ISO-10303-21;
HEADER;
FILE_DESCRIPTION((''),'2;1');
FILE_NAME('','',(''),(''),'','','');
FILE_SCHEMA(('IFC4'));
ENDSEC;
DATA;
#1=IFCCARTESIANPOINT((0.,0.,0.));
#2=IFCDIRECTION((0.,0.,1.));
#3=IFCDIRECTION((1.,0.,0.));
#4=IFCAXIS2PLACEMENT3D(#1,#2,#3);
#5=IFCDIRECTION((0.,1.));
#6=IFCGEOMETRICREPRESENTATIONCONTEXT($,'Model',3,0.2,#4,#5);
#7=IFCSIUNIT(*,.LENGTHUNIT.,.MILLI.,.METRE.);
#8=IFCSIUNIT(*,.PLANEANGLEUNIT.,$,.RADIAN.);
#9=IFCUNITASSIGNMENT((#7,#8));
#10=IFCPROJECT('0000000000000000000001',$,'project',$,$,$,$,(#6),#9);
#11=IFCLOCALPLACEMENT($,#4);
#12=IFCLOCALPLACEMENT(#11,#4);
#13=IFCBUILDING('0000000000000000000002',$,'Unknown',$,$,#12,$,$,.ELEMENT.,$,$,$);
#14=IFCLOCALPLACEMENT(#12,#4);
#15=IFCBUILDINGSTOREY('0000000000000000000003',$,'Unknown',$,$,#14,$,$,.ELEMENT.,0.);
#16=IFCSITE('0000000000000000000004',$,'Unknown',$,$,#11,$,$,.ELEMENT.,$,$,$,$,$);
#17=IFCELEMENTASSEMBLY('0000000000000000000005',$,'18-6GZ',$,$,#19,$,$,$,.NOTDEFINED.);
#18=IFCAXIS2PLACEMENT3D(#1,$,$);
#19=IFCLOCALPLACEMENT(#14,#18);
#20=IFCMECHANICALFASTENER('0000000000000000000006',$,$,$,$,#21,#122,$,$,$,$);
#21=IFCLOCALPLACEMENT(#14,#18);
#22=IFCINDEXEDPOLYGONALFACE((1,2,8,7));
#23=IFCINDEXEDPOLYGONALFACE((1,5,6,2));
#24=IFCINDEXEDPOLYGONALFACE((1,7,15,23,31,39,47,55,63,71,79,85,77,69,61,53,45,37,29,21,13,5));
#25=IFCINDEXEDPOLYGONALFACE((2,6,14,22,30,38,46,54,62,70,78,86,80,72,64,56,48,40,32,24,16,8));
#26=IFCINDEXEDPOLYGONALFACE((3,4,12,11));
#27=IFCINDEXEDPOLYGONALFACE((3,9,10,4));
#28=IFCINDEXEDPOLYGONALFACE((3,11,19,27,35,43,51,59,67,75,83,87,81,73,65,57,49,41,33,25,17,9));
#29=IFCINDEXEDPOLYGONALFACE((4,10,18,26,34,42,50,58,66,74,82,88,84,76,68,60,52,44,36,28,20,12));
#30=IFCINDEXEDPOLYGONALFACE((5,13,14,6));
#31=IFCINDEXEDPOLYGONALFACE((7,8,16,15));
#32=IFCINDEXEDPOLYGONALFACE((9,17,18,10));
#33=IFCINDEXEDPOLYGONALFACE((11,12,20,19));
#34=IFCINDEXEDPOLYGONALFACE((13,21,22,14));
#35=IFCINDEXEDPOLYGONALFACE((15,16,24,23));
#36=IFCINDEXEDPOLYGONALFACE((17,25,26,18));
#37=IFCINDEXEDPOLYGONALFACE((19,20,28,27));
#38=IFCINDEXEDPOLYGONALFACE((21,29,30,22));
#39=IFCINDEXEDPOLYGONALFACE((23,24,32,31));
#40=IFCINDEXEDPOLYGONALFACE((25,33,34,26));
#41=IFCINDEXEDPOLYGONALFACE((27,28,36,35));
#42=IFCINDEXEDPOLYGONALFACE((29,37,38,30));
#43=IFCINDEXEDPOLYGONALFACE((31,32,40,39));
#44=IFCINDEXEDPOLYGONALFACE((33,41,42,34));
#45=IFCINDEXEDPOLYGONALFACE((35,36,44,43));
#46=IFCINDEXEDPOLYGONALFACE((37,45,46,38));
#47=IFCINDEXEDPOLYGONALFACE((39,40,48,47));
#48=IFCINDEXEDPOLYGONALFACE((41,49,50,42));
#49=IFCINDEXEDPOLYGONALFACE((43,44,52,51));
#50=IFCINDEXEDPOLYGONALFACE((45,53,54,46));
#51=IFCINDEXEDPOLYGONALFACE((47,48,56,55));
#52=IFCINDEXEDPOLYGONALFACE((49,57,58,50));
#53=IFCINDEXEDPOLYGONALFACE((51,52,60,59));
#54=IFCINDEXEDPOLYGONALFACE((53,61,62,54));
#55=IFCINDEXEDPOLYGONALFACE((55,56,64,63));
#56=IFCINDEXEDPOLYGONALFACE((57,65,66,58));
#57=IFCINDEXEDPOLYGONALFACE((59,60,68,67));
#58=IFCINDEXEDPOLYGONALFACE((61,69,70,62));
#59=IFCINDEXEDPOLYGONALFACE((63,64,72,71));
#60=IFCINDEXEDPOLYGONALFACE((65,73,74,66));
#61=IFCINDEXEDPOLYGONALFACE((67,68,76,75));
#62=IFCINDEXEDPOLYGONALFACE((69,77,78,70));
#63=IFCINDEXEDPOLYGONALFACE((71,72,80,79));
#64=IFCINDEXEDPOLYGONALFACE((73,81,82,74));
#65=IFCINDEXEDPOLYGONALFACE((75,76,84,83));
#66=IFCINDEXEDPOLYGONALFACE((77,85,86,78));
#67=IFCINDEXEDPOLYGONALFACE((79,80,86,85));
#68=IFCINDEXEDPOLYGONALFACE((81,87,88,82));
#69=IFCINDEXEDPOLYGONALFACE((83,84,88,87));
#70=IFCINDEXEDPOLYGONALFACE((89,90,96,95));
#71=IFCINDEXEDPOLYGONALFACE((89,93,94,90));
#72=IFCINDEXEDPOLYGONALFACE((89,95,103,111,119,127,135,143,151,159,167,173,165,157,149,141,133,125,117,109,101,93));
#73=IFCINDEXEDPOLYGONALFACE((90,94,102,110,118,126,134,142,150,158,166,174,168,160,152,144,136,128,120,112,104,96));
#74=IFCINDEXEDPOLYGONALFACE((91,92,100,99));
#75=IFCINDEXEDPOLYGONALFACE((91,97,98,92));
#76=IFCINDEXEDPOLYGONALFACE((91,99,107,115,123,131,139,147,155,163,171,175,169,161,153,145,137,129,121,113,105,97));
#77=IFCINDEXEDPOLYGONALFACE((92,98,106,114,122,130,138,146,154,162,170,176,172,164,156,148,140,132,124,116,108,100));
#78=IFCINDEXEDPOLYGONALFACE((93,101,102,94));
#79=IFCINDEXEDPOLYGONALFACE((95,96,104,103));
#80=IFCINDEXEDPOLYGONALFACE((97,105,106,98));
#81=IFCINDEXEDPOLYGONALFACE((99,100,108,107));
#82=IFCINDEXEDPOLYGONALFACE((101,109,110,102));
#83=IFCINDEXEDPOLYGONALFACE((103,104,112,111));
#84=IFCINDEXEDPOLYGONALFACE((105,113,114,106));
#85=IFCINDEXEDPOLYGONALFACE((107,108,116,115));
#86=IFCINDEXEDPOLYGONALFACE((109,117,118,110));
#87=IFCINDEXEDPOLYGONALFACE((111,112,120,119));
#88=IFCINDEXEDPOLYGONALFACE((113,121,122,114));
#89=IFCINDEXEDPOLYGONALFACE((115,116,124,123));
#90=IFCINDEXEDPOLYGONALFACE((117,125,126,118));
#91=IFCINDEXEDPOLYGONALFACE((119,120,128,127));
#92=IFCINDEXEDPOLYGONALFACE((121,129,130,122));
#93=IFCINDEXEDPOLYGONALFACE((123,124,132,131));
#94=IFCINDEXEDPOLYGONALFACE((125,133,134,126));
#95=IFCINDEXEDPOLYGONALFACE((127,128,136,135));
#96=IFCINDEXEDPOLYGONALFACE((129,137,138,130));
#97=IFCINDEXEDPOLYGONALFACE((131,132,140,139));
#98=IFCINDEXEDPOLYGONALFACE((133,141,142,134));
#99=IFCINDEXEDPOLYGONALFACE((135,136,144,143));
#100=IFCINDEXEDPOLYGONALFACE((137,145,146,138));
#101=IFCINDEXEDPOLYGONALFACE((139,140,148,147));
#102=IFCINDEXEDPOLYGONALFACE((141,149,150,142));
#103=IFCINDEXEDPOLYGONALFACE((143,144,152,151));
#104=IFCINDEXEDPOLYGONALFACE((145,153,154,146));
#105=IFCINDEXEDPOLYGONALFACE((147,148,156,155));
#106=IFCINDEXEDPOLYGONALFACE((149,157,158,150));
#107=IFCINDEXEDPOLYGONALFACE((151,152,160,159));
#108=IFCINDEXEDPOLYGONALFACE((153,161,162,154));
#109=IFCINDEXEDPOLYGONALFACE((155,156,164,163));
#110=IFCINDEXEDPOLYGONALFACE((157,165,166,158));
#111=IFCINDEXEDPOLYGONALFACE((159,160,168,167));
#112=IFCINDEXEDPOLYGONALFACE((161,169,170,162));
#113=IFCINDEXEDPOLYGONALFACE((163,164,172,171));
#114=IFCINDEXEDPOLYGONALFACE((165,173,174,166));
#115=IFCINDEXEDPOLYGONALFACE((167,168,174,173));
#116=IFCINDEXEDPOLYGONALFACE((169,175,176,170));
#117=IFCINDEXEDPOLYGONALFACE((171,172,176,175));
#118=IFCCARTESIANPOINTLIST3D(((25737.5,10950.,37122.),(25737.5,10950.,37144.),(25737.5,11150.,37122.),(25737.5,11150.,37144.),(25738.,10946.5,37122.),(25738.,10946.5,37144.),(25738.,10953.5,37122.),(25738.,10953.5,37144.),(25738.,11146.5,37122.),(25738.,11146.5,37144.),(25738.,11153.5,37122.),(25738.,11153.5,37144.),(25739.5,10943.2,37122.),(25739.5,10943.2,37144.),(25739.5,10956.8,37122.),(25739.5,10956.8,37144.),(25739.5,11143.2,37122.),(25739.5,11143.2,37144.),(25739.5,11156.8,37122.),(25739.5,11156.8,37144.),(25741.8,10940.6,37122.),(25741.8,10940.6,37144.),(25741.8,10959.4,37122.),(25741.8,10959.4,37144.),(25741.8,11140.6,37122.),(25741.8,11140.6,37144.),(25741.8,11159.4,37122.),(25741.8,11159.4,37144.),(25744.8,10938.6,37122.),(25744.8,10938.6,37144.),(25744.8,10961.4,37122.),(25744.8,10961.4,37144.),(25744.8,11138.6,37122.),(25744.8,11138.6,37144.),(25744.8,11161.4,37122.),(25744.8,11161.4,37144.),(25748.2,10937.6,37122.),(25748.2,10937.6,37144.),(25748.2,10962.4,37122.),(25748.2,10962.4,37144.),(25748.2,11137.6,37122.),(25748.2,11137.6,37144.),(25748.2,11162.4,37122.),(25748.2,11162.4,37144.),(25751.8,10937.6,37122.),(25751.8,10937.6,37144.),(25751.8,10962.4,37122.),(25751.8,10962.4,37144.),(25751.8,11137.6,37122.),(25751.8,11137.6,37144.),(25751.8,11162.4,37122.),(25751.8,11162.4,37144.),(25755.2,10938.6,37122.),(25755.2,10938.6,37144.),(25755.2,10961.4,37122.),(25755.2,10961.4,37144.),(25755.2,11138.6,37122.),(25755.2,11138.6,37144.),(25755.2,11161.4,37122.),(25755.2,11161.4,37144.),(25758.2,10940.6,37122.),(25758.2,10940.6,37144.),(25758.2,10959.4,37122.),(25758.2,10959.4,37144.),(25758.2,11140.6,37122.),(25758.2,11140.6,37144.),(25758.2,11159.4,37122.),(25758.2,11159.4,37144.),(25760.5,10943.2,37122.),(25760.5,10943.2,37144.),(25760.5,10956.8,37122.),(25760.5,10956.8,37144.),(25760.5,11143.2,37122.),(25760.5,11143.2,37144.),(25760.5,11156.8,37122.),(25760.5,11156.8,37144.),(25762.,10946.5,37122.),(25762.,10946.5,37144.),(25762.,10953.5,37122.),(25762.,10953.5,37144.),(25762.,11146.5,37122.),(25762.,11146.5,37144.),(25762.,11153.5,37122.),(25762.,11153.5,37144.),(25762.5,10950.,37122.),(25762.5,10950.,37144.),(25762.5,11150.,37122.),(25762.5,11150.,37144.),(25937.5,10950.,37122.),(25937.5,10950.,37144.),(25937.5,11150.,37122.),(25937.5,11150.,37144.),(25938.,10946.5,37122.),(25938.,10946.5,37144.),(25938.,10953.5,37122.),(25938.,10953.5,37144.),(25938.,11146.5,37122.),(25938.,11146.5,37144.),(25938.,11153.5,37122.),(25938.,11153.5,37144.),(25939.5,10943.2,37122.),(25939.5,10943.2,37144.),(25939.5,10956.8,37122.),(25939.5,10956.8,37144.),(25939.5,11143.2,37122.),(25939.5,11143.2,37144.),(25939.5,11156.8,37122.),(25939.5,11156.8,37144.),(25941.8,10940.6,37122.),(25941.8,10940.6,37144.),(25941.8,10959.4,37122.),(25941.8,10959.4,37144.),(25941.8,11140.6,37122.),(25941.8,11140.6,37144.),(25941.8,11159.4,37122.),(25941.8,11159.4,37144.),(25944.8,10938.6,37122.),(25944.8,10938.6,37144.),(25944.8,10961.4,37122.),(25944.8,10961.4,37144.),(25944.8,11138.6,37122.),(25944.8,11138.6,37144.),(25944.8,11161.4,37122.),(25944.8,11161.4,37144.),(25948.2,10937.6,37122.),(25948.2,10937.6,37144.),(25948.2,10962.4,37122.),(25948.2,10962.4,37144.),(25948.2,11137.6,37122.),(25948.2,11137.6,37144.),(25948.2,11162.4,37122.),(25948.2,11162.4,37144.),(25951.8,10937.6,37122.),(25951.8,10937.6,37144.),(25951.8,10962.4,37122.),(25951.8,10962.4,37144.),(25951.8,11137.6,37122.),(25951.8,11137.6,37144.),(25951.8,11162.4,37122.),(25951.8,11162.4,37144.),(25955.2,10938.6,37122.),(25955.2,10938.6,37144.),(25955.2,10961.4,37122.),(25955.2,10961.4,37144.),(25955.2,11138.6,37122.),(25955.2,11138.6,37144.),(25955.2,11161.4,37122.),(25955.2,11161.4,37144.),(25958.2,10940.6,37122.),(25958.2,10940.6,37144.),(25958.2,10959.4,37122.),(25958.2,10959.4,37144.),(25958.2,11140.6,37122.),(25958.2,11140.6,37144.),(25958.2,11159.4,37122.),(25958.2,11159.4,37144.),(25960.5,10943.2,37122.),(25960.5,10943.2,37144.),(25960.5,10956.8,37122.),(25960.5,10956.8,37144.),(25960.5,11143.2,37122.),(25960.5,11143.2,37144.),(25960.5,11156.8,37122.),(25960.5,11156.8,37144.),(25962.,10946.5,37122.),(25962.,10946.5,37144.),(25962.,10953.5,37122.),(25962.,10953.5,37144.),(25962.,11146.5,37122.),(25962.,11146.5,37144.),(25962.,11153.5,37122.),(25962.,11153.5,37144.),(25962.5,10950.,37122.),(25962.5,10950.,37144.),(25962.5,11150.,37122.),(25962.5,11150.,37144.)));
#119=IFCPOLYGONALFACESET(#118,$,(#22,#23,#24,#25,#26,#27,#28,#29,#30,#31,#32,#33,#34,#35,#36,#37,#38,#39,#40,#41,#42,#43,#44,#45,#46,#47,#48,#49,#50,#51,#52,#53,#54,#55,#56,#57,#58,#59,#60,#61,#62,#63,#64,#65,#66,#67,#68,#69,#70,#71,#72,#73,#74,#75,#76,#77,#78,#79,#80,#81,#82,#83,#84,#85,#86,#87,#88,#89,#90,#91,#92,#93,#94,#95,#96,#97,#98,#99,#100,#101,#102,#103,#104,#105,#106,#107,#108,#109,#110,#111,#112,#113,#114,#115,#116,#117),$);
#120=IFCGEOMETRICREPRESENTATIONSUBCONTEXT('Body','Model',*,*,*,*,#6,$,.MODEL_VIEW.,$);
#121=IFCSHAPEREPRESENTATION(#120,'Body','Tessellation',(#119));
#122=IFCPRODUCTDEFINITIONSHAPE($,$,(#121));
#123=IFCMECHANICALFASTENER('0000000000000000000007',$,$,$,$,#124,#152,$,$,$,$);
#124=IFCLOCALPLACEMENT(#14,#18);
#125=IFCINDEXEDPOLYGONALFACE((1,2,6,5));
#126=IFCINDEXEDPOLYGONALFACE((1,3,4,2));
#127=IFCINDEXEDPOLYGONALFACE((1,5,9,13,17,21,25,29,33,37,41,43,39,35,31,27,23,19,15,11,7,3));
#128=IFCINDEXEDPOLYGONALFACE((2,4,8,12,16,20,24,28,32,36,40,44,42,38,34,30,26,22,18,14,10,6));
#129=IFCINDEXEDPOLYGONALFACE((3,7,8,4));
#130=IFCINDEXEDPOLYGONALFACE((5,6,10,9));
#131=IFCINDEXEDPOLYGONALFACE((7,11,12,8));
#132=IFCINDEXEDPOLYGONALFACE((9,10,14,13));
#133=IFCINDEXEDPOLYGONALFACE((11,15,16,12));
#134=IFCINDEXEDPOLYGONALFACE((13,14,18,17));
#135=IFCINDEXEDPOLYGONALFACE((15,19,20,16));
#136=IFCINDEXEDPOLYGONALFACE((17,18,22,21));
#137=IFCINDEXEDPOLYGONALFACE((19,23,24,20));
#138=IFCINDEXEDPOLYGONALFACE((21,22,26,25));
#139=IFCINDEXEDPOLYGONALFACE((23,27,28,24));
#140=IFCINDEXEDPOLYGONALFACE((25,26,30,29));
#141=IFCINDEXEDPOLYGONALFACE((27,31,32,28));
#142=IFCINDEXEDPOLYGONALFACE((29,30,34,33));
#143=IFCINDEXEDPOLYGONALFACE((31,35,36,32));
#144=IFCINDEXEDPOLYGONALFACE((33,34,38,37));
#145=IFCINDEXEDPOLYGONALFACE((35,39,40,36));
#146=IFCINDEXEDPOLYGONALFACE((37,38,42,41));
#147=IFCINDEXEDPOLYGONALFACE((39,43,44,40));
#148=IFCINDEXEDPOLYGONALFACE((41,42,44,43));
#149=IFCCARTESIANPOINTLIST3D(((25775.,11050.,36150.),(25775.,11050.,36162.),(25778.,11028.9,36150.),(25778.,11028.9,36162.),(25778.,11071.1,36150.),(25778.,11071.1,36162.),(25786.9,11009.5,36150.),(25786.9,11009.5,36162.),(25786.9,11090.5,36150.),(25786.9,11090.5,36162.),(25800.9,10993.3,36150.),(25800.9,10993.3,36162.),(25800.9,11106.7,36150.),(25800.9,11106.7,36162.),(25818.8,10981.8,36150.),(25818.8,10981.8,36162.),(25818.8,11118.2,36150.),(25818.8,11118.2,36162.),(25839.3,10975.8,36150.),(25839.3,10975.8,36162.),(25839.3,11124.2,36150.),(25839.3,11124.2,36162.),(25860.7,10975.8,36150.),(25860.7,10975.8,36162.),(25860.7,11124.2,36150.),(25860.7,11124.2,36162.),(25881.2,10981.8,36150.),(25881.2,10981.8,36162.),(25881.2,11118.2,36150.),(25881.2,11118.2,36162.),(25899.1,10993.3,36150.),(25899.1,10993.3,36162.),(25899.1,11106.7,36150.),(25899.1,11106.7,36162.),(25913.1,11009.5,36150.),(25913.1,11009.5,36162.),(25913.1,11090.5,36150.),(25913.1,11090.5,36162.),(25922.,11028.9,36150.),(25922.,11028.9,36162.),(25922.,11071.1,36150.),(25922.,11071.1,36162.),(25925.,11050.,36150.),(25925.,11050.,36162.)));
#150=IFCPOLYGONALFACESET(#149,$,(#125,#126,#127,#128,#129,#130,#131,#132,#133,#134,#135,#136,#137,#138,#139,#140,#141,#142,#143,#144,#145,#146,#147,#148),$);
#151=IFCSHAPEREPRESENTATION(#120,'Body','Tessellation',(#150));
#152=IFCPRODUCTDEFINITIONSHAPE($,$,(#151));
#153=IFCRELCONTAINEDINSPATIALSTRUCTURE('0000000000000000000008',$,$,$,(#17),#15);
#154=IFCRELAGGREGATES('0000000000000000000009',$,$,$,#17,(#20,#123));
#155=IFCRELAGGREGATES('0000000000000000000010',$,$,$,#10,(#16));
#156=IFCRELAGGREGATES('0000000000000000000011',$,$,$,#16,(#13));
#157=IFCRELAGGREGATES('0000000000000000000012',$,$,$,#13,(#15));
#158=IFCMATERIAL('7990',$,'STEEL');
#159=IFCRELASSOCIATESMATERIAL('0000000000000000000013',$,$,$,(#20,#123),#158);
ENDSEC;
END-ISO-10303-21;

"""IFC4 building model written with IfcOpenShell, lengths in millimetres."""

from ifc_helpers import new_model, si_unit, direction, frame, origin_with_axes, place, context, subcontext, project, spatial, arc, indexed_curve, outline, extrude, source, transform, mapped, material, element, aggregate, save


model = new_model("IFC4")

# Units and contexts
model_context = context("Model", 3, precision=0.2, world=origin_with_axes(), true_north=direction((0.0, 1.0)))
body_context = subcontext(model_context, "Body", "Model", "MODEL_VIEW")
ifc_project = project(units=[si_unit("LENGTHUNIT", "METRE", prefix="MILLI"), si_unit("PLANEANGLEUNIT", "RADIAN")], contexts=[model_context])

# Site, building, storey
site_placement = place(None, origin_with_axes())
site = spatial("IfcSite", under=ifc_project, at=site_placement, Name="Unknown", CompositionType="ELEMENT")
building_placement = place(site_placement, origin_with_axes())
building = spatial("IfcBuilding", under=site, at=building_placement, Name="Unknown", CompositionType="ELEMENT")
storey_placement = place(building_placement, origin_with_axes())
storey = spatial("IfcBuildingStorey", under=building, at=storey_placement, Name="Unknown", CompositionType="ELEMENT", Elevation=0.0)

# Element assembly
assembly_1_placement = place(storey_placement, frame((25850.0, 11050.0, 35950.0), z_axis=(-1.0, 0.0, 0.0), x_axis=(0.0, 0.0, 1.0)))
assembly_1 = element("IfcElementAssembly", 1, at=assembly_1_placement, inside=storey, Name="18-6GZ", PredefinedType="NOTDEFINED")

# Mechanical fasteners
ifc_material_1 = material(Name="7990", Category="STEEL")
placement_1 = place(assembly_1_placement, frame((1172.0, 0.0, 0.0), z_axis=(-1.0, 0.0, 0.0), x_axis=(0.0, 1.0, 0.0)))
shared_shape_1 = source(origin_with_axes(), body_context, "Body", "SweptSolid", [
    extrude(outline(indexed_curve([(12.5, 0.0), (0.0, 12.5), (-12.5, 0.0), (0.0, -12.5)], segments=[arc(1, 2, 3), arc(3, 4, 1)])), frame((0.0, 0.0, 0.0), z_axis=(0.0, 0.0, -1.0), x_axis=(0.0, 1.0, 0.0)), (0.0, 0.0, 1.0), 22.0),
])
mechanical_fastener_1 = element("IfcMechanicalFastener", 2, at=placement_1, material=ifc_material_1, context=body_context, shape_type="MappedRepresentation", body=[
    mapped(shared_shape_1, transform((-100.0, -100.0, 0.0))),
    mapped(shared_shape_1, transform((100.0, -100.0, 0.0))),
    mapped(shared_shape_1, transform((-100.0, 100.0, 0.0))),
    mapped(shared_shape_1, transform((100.0, 100.0, 0.0))),
])
shared_shape_2 = source(origin_with_axes(), body_context, "Body", "SweptSolid", [
    extrude(outline(indexed_curve([(75.0, 0.0), (0.0, 75.0), (-75.0, 0.0), (0.0, -75.0)], segments=[arc(1, 2, 3), arc(3, 4, 1)])), frame((0.0, 0.0, 0.0), z_axis=(0.0, 0.0, -1.0), x_axis=(0.0, 1.0, 0.0)), (0.0, 0.0, 1.0), 12.0),
])
placement_2 = place(assembly_1_placement, frame((212.0, 0.0, 0.0), z_axis=(1.0, 0.0, 0.0), x_axis=(0.0, 1.0, 0.0)))
mechanical_fastener_2 = element("IfcMechanicalFastener", 3, at=placement_2, material=ifc_material_1, context=body_context, shape_type="MappedRepresentation", body=[
    mapped(shared_shape_2, transform((0.0, 0.0, 0.0))),
])
aggregate(assembly_1, [mechanical_fastener_1, mechanical_fastener_2])

save(model, "model.ifc")
